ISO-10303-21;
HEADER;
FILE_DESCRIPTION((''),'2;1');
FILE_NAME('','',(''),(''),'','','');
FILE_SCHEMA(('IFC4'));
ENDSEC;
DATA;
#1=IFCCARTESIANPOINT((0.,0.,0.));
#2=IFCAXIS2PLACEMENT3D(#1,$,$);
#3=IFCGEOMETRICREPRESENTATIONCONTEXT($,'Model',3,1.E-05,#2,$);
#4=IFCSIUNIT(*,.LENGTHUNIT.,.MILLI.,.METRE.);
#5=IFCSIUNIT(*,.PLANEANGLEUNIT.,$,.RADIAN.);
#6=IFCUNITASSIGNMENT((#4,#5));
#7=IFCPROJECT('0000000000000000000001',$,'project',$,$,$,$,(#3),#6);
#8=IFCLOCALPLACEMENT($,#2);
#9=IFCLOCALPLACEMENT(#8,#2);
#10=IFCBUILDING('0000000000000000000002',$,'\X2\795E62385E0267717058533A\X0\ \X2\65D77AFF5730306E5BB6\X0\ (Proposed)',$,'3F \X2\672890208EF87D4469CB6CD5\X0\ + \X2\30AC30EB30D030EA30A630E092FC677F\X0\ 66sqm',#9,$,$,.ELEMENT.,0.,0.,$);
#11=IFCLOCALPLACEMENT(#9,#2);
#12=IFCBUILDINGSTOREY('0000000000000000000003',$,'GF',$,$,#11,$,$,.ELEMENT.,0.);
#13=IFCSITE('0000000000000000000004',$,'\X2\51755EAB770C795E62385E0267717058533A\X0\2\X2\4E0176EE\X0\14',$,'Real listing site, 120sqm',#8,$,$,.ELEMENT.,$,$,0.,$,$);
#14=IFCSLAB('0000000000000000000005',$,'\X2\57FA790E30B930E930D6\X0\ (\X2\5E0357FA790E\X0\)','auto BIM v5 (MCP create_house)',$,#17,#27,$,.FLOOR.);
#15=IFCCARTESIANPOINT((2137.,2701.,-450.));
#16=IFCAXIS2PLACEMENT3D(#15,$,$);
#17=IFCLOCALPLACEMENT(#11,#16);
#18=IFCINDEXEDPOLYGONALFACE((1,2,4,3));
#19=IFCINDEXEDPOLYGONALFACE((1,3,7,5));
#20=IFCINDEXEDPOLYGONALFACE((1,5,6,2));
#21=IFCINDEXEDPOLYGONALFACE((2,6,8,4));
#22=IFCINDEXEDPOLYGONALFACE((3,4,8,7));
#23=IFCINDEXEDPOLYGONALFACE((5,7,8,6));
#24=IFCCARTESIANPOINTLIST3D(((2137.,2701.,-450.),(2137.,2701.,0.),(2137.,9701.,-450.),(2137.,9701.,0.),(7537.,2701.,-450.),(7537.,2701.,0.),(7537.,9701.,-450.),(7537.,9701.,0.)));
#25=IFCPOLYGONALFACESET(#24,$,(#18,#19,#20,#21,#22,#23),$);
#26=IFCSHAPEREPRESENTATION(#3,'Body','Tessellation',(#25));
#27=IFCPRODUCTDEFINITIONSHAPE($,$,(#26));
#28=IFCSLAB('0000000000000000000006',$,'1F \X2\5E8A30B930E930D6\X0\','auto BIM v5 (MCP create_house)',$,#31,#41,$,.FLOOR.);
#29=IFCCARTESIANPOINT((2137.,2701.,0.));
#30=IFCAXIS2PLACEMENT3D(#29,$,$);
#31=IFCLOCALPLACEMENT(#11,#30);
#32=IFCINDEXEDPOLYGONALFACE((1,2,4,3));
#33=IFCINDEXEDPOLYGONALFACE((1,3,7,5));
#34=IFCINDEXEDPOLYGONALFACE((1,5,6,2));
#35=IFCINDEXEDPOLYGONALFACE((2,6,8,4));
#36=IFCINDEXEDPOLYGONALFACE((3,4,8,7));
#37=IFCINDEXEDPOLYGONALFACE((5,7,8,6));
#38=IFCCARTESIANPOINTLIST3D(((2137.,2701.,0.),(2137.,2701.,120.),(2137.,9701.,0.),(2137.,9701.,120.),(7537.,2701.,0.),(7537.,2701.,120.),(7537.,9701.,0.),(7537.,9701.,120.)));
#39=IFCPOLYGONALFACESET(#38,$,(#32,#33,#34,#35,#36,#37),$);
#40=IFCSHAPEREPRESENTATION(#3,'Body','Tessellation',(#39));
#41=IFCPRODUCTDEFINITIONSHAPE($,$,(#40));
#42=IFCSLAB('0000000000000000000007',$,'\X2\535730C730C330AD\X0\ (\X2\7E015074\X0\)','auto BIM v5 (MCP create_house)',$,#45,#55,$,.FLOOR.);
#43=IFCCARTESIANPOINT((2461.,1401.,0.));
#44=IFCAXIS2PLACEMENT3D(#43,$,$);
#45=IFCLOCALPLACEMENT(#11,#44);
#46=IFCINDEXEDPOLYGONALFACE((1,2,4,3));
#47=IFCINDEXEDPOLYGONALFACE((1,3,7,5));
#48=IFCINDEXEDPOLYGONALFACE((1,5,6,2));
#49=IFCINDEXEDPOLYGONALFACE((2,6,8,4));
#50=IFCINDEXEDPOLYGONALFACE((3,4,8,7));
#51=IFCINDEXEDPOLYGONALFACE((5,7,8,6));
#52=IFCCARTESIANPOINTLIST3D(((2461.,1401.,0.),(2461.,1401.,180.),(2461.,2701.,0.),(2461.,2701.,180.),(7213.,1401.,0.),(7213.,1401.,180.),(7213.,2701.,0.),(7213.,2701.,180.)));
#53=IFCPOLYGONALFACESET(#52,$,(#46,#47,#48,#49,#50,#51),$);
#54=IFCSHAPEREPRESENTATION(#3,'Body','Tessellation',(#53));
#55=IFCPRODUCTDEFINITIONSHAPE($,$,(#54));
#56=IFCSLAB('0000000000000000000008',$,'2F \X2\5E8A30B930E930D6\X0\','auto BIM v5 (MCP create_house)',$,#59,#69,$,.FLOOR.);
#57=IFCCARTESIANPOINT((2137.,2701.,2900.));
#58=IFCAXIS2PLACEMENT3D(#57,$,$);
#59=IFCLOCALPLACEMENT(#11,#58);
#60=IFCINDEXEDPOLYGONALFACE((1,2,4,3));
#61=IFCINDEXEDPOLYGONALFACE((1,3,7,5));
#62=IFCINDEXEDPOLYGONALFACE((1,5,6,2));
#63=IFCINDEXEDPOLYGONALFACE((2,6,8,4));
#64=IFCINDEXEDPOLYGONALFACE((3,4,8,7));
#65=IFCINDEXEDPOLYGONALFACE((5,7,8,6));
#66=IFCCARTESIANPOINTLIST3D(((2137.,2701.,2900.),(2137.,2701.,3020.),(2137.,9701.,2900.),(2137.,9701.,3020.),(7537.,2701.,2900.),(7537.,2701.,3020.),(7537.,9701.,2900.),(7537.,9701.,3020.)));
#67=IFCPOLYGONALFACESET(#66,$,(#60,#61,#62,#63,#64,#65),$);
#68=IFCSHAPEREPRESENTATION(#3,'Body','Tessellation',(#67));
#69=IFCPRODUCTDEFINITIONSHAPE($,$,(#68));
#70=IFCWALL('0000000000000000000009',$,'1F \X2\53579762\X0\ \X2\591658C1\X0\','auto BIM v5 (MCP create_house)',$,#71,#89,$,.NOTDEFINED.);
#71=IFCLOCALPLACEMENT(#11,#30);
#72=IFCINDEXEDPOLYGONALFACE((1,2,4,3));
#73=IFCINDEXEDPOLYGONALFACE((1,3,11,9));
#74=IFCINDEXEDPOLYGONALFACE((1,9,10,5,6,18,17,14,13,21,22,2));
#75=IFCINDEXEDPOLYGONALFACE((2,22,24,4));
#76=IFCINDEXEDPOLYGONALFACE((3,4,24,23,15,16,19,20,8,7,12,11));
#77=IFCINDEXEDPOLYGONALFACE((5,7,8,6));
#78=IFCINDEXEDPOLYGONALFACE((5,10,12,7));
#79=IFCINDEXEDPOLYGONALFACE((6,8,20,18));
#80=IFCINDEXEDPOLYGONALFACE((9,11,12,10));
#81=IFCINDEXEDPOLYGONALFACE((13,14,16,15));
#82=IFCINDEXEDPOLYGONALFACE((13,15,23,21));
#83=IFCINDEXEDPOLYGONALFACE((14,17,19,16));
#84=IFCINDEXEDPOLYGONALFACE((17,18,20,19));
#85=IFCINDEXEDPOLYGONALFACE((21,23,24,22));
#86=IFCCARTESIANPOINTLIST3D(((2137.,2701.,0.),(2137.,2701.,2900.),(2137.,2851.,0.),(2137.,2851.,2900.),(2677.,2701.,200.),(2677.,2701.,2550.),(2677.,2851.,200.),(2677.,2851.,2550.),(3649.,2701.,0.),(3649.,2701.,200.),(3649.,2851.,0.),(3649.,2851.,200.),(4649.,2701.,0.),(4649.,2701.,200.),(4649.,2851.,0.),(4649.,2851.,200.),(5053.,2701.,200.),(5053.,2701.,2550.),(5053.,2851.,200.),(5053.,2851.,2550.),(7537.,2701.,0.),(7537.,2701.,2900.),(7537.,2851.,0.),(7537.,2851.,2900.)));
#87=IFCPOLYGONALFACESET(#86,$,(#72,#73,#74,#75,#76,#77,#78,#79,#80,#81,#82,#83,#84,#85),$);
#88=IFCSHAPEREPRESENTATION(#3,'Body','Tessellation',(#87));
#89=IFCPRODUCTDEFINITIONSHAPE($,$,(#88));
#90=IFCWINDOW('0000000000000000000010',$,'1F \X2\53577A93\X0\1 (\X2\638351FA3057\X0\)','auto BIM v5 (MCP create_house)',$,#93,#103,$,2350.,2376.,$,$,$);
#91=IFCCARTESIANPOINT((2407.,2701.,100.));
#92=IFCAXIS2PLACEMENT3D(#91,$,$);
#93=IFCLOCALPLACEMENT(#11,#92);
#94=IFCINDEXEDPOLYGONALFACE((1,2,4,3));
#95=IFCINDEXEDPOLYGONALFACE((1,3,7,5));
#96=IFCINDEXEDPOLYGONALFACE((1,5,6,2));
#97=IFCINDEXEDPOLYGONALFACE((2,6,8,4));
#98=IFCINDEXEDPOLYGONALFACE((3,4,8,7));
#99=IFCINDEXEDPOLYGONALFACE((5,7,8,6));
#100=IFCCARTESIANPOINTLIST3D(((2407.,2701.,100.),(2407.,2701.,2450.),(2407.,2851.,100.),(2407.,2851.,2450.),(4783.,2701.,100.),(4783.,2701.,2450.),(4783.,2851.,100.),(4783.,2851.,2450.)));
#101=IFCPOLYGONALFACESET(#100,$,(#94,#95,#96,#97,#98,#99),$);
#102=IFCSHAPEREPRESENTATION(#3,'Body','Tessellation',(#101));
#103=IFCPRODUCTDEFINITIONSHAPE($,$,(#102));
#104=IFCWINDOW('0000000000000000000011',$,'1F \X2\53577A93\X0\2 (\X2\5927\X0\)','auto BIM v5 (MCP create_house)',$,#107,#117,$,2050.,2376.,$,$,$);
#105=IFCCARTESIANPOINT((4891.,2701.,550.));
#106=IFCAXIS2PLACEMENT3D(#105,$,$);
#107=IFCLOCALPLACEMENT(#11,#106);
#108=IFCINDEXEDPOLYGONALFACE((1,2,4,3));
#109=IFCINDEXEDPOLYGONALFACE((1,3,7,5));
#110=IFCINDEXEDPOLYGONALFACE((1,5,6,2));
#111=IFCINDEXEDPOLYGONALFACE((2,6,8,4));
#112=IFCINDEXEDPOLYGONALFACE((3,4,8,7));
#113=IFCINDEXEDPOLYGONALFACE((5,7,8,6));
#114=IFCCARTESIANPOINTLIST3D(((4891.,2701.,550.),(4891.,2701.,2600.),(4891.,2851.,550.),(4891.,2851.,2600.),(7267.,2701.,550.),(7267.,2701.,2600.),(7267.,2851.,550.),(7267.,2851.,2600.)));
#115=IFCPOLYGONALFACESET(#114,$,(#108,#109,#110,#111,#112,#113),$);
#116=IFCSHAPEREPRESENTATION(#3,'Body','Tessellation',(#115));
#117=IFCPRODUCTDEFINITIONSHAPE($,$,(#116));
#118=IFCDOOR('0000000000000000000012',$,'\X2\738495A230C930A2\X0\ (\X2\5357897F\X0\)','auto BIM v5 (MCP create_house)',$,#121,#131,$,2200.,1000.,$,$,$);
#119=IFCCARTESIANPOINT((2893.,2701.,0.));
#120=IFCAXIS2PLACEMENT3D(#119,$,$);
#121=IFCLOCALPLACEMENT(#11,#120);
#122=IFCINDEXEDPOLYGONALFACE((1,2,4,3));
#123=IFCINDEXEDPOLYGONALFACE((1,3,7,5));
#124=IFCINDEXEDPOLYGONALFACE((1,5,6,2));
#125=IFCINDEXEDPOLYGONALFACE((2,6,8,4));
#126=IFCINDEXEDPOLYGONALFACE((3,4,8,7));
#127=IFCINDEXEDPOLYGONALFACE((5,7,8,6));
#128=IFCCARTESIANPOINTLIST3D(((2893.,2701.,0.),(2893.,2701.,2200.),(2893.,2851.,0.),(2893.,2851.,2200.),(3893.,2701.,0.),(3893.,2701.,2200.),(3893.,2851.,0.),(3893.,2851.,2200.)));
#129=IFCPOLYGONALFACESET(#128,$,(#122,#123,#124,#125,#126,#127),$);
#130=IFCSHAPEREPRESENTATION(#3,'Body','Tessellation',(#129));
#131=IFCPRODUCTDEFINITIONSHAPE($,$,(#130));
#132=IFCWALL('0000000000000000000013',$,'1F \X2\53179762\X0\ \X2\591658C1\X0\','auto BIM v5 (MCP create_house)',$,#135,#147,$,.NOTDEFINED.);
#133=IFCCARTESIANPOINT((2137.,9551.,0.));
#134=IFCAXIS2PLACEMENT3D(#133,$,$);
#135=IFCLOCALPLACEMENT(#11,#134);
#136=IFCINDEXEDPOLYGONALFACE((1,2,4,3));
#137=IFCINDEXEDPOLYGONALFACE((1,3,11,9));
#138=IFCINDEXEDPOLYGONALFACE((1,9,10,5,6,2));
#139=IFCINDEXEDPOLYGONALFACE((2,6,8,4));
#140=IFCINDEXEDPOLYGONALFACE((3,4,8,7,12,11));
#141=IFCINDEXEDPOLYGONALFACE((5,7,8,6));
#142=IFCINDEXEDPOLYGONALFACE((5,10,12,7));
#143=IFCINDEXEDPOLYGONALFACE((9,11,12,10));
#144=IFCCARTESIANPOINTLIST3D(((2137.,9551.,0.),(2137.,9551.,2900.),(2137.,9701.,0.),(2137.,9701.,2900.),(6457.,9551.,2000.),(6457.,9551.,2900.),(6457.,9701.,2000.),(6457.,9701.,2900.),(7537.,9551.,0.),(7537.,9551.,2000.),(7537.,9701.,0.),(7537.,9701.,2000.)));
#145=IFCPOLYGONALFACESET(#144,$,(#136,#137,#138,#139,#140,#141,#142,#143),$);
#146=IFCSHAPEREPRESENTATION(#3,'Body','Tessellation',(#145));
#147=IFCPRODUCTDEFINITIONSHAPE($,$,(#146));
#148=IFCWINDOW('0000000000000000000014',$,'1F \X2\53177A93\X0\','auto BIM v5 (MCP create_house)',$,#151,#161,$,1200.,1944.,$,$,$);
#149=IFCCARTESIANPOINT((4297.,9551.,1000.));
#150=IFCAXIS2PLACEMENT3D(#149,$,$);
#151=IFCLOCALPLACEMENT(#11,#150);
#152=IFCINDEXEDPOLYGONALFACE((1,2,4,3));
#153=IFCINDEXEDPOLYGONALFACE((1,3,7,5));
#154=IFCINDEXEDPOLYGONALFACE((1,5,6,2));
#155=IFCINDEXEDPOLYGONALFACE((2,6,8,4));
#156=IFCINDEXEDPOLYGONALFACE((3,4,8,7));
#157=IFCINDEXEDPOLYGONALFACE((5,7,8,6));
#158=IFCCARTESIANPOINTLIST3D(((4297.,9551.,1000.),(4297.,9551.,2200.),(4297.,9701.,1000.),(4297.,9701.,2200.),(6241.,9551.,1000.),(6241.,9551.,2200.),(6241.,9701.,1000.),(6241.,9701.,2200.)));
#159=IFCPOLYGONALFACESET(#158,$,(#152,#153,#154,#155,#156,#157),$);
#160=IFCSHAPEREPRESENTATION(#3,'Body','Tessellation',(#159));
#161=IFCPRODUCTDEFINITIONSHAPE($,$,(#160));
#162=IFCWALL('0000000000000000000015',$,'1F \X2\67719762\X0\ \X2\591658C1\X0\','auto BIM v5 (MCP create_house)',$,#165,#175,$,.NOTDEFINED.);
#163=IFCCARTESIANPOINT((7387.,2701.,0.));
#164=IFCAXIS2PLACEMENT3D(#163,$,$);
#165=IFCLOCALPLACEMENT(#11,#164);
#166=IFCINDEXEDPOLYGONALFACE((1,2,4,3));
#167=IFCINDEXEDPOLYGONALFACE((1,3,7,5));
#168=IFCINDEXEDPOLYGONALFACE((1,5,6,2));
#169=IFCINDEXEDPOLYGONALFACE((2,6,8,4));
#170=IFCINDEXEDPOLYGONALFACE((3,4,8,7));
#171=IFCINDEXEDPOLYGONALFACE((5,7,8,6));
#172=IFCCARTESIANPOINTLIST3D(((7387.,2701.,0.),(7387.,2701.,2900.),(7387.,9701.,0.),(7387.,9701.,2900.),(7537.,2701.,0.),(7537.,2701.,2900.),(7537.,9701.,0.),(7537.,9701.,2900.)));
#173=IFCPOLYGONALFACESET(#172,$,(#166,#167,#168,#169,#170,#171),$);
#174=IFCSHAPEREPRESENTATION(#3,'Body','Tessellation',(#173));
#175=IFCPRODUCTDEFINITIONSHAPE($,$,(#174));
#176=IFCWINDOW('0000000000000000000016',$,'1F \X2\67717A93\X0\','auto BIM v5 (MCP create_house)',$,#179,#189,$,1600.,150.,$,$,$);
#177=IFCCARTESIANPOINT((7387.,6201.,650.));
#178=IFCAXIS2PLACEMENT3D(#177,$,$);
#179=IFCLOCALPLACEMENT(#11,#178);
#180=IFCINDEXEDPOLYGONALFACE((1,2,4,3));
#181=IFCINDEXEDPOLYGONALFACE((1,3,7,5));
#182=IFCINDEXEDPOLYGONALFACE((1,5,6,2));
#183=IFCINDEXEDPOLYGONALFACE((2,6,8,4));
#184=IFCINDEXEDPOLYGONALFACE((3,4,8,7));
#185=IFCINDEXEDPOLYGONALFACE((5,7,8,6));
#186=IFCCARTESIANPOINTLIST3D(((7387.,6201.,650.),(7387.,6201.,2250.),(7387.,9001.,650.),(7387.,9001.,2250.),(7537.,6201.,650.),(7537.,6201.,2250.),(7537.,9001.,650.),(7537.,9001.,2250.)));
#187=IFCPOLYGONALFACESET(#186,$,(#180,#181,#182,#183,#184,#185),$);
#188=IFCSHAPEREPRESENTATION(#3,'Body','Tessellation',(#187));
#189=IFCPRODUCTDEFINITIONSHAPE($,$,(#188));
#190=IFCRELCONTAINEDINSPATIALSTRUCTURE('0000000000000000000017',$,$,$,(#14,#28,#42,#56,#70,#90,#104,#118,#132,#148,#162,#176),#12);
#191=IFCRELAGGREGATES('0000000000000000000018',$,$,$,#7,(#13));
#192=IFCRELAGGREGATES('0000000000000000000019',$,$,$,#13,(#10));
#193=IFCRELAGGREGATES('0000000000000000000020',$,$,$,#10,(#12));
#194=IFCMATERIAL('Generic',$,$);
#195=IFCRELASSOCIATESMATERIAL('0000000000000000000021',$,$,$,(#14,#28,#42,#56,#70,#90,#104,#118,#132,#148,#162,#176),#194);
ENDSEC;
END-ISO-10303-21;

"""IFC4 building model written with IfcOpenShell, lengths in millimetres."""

from ifc_helpers import new_model, si_unit, frame, frame_2d, origin, place, context, project, spatial, rectangle, extrude, material, element, fill, save


model = new_model("IFC4")

# Units and contexts
model_context = context("Model", 3, precision=1e-05, world=origin())
ifc_project = project(units=[si_unit("LENGTHUNIT", "METRE", prefix="MILLI"), si_unit("PLANEANGLEUNIT", "RADIAN")], contexts=[model_context])

# Site, building, storey
site_placement = place(None, origin())
site = spatial("IfcSite", under=ifc_project, at=site_placement, Name="兵庫県神戸市東灘区2丁目14", ObjectType="Real listing site, 120sqm", CompositionType="ELEMENT", RefElevation=0.0)
building_placement = place(site_placement, origin())
building = spatial("IfcBuilding", under=site, at=building_placement, Name="神戸市東灘区 旗竿地の家 (Proposed)", ObjectType="3F 木造軸組構法 + ガルバリウム鋼板 66sqm", CompositionType="ELEMENT", ElevationOfRefHeight=0.0, ElevationOfTerrain=0.0)
storey_placement = place(building_placement, origin())
storey = spatial("IfcBuildingStorey", under=building, at=storey_placement, Name="GF", CompositionType="ELEMENT", Elevation=0.0)

# Slabs
ifc_material = material(Name="Generic")
slab_1_placement = place(storey_placement, frame((2137.0, 2701.0, -450.0)))
element("IfcSlab", 1, at=slab_1_placement, inside=storey, material=ifc_material, Name="基礎スラブ (布基礎)", Description="auto BIM v5 (MCP create_house)", PredefinedType="FLOOR", context=model_context, shape_type="SweptSolid", body=[
    extrude(rectangle(XDim=5400.0, YDim=7000.0, at=frame_2d((2700.0, 3500.0))), frame((2137.0, 2701.0, -450.0)), (0.0, 0.0, 1.0), 450.0),
])
slab_2_placement = place(storey_placement, frame((2137.0, 2701.0, 0.0)))
element("IfcSlab", 2, at=slab_2_placement, inside=storey, material=ifc_material, Name="1F 床スラブ", Description="auto BIM v5 (MCP create_house)", PredefinedType="FLOOR", context=model_context, shape_type="SweptSolid", body=[
    extrude(rectangle(XDim=5400.0, YDim=7000.0, at=frame_2d((2700.0, 3500.0))), frame((2137.0, 2701.0, 0.0)), (0.0, 0.0, 1.0), 120.0),
])
slab_3_placement = place(storey_placement, frame((2461.0, 1401.0, 0.0)))
element("IfcSlab", 3, at=slab_3_placement, inside=storey, material=ifc_material, Name="南デッキ (縁側)", Description="auto BIM v5 (MCP create_house)", PredefinedType="FLOOR", context=model_context, shape_type="SweptSolid", body=[
    extrude(rectangle(XDim=4752.0, YDim=1300.0, at=frame_2d((2376.0, 650.0))), frame((2461.0, 1401.0, 0.0)), (0.0, 0.0, 1.0), 180.0),
])
slab_4_placement = place(storey_placement, frame((2137.0, 2701.0, 2900.0)))
element("IfcSlab", 4, at=slab_4_placement, inside=storey, material=ifc_material, Name="2F 床スラブ", Description="auto BIM v5 (MCP create_house)", PredefinedType="FLOOR", context=model_context, shape_type="SweptSolid", body=[
    extrude(rectangle(XDim=5400.0, YDim=7000.0, at=frame_2d((2700.0, 3500.0))), frame((2137.0, 2701.0, 2900.0)), (0.0, 0.0, 1.0), 120.0),
])

# Wall, openings, windows, door
wall_1_placement = place(storey_placement, frame((2137.0, 2701.0, 0.0)))
wall_1 = element("IfcWall", 5, at=wall_1_placement, inside=storey, material=ifc_material, Name="1F 南面 外壁", Description="auto BIM v5 (MCP create_house)", PredefinedType="NOTDEFINED", context=model_context, shape_type="SweptSolid", body=[
    extrude(rectangle(XDim=5400.0, YDim=150.0, at=frame_2d((2700.0, 75.0))), frame((2137.0, 2701.0, 0.0)), (0.0, 0.0, 1.0), 2900.0),
])
opening_1_placement = place(storey_placement, frame((2407.0, 2701.0, 100.0)))
opening_1 = element("IfcOpeningElement", 6, at=opening_1_placement, cuts=wall_1, PredefinedType="NOTDEFINED", context=model_context, shape_type="SweptSolid", body=[
    extrude(rectangle(XDim=2376.0, YDim=150.0, at=frame_2d((1188.0, 75.0))), frame((2407.0, 2701.0, 100.0)), (0.0, 0.0, 1.0), 2350.0),
])
opening_2_placement = place(storey_placement, frame((4891.0, 2701.0, 550.0)))
opening_2 = element("IfcOpeningElement", 7, at=opening_2_placement, cuts=wall_1, PredefinedType="NOTDEFINED", context=model_context, shape_type="SweptSolid", body=[
    extrude(rectangle(XDim=2376.0, YDim=150.0, at=frame_2d((1188.0, 75.0))), frame((4891.0, 2701.0, 550.0)), (0.0, 0.0, 1.0), 2050.0),
])
opening_3_placement = place(storey_placement, frame((2893.0, 2701.0, 0.0)))
opening_3 = element("IfcOpeningElement", 8, at=opening_3_placement, cuts=wall_1, PredefinedType="NOTDEFINED", context=model_context, shape_type="SweptSolid", body=[
    extrude(rectangle(XDim=1000.0, YDim=150.0, at=frame_2d((500.0, 75.0))), frame((2893.0, 2701.0, 0.0)), (0.0, 0.0, 1.0), 2200.0),
])
window_1_placement = place(storey_placement, frame((2407.0, 2701.0, 100.0)))
window_1 = element("IfcWindow", 9, at=window_1_placement, inside=storey, material=ifc_material, Name="1F 南窓1 (掃出し)", Description="auto BIM v5 (MCP create_house)", OverallHeight=2350.0, OverallWidth=2376.0, context=model_context, shape_type="SweptSolid", body=[
    extrude(rectangle(XDim=2376.0, YDim=150.0, at=frame_2d((1188.0, 75.0))), frame((2407.0, 2701.0, 100.0)), (0.0, 0.0, 1.0), 2350.0),
])
fill(opening_1, window_1)
window_2_placement = place(storey_placement, frame((4891.0, 2701.0, 550.0)))
window_2 = element("IfcWindow", 10, at=window_2_placement, inside=storey, material=ifc_material, Name="1F 南窓2 (大)", Description="auto BIM v5 (MCP create_house)", OverallHeight=2050.0, OverallWidth=2376.0, context=model_context, shape_type="SweptSolid", body=[
    extrude(rectangle(XDim=2376.0, YDim=150.0, at=frame_2d((1188.0, 75.0))), frame((4891.0, 2701.0, 550.0)), (0.0, 0.0, 1.0), 2050.0),
])
fill(opening_2, window_2)
door_placement = place(storey_placement, frame((2893.0, 2701.0, 0.0)))
door = element("IfcDoor", 11, at=door_placement, inside=storey, material=ifc_material, Name="玄関ドア (南西)", Description="auto BIM v5 (MCP create_house)", OverallHeight=2200.0, OverallWidth=1000.0, context=model_context, shape_type="SweptSolid", body=[
    extrude(rectangle(XDim=1000.0, YDim=150.0, at=frame_2d((500.0, 75.0))), frame((2893.0, 2701.0, 0.0)), (0.0, 0.0, 1.0), 2200.0),
])
fill(opening_3, door)

# Walls, openings, windows
wall_2_placement = place(storey_placement, frame((2137.0, 9551.0, 0.0)))
wall_2 = element("IfcWall", 12, at=wall_2_placement, inside=storey, material=ifc_material, Name="1F 北面 外壁", Description="auto BIM v5 (MCP create_house)", PredefinedType="NOTDEFINED", context=model_context, shape_type="SweptSolid", body=[
    extrude(rectangle(XDim=5400.0, YDim=150.0, at=frame_2d((2700.0, 75.0))), frame((2137.0, 9551.0, 0.0)), (0.0, 0.0, 1.0), 2900.0),
])
opening_4_placement = place(storey_placement, frame((4297.0, 9551.0, 1000.0)))
opening_4 = element("IfcOpeningElement", 13, at=opening_4_placement, cuts=wall_2, PredefinedType="NOTDEFINED", context=model_context, shape_type="SweptSolid", body=[
    extrude(rectangle(XDim=1944.0, YDim=150.0, at=frame_2d((972.0, 75.0))), frame((4297.0, 9551.0, 1000.0)), (0.0, 0.0, 1.0), 1200.0),
])
window_3_placement = place(storey_placement, frame((4297.0, 9551.0, 1000.0)))
window_3 = element("IfcWindow", 14, at=window_3_placement, inside=storey, material=ifc_material, Name="1F 北窓", Description="auto BIM v5 (MCP create_house)", OverallHeight=1200.0, OverallWidth=1944.0, context=model_context, shape_type="SweptSolid", body=[
    extrude(rectangle(XDim=1944.0, YDim=150.0, at=frame_2d((972.0, 75.0))), frame((4297.0, 9551.0, 1000.0)), (0.0, 0.0, 1.0), 1200.0),
])
fill(opening_4, window_3)
wall_3_placement = place(storey_placement, frame((7387.0, 2701.0, 0.0)))
wall_3 = element("IfcWall", 15, at=wall_3_placement, inside=storey, material=ifc_material, Name="1F 東面 外壁", Description="auto BIM v5 (MCP create_house)", PredefinedType="NOTDEFINED", context=model_context, shape_type="SweptSolid", body=[
    extrude(rectangle(XDim=150.0, YDim=7000.0, at=frame_2d((75.0, 3500.0))), frame((7387.0, 2701.0, 0.0)), (0.0, 0.0, 1.0), 2900.0),
])
opening_5_placement = place(storey_placement, frame((7387.0, 6201.0, 650.0)))
opening_5 = element("IfcOpeningElement", 16, at=opening_5_placement, cuts=wall_3, PredefinedType="NOTDEFINED", context=model_context, shape_type="SweptSolid", body=[
    extrude(rectangle(XDim=150.0, YDim=2800.0, at=frame_2d((75.0, 1400.0))), frame((7387.0, 6201.0, 650.0)), (0.0, 0.0, 1.0), 1600.0),
])
window_4_placement = place(storey_placement, frame((7387.0, 6201.0, 650.0)))
window_4 = element("IfcWindow", 17, at=window_4_placement, inside=storey, material=ifc_material, Name="1F 東窓", Description="auto BIM v5 (MCP create_house)", OverallHeight=1600.0, OverallWidth=150.0, context=model_context, shape_type="SweptSolid", body=[
    extrude(rectangle(XDim=150.0, YDim=2800.0, at=frame_2d((75.0, 1400.0))), frame((7387.0, 6201.0, 650.0)), (0.0, 0.0, 1.0), 1600.0),
])
fill(opening_5, window_4)

save(model, "model.ifc")
